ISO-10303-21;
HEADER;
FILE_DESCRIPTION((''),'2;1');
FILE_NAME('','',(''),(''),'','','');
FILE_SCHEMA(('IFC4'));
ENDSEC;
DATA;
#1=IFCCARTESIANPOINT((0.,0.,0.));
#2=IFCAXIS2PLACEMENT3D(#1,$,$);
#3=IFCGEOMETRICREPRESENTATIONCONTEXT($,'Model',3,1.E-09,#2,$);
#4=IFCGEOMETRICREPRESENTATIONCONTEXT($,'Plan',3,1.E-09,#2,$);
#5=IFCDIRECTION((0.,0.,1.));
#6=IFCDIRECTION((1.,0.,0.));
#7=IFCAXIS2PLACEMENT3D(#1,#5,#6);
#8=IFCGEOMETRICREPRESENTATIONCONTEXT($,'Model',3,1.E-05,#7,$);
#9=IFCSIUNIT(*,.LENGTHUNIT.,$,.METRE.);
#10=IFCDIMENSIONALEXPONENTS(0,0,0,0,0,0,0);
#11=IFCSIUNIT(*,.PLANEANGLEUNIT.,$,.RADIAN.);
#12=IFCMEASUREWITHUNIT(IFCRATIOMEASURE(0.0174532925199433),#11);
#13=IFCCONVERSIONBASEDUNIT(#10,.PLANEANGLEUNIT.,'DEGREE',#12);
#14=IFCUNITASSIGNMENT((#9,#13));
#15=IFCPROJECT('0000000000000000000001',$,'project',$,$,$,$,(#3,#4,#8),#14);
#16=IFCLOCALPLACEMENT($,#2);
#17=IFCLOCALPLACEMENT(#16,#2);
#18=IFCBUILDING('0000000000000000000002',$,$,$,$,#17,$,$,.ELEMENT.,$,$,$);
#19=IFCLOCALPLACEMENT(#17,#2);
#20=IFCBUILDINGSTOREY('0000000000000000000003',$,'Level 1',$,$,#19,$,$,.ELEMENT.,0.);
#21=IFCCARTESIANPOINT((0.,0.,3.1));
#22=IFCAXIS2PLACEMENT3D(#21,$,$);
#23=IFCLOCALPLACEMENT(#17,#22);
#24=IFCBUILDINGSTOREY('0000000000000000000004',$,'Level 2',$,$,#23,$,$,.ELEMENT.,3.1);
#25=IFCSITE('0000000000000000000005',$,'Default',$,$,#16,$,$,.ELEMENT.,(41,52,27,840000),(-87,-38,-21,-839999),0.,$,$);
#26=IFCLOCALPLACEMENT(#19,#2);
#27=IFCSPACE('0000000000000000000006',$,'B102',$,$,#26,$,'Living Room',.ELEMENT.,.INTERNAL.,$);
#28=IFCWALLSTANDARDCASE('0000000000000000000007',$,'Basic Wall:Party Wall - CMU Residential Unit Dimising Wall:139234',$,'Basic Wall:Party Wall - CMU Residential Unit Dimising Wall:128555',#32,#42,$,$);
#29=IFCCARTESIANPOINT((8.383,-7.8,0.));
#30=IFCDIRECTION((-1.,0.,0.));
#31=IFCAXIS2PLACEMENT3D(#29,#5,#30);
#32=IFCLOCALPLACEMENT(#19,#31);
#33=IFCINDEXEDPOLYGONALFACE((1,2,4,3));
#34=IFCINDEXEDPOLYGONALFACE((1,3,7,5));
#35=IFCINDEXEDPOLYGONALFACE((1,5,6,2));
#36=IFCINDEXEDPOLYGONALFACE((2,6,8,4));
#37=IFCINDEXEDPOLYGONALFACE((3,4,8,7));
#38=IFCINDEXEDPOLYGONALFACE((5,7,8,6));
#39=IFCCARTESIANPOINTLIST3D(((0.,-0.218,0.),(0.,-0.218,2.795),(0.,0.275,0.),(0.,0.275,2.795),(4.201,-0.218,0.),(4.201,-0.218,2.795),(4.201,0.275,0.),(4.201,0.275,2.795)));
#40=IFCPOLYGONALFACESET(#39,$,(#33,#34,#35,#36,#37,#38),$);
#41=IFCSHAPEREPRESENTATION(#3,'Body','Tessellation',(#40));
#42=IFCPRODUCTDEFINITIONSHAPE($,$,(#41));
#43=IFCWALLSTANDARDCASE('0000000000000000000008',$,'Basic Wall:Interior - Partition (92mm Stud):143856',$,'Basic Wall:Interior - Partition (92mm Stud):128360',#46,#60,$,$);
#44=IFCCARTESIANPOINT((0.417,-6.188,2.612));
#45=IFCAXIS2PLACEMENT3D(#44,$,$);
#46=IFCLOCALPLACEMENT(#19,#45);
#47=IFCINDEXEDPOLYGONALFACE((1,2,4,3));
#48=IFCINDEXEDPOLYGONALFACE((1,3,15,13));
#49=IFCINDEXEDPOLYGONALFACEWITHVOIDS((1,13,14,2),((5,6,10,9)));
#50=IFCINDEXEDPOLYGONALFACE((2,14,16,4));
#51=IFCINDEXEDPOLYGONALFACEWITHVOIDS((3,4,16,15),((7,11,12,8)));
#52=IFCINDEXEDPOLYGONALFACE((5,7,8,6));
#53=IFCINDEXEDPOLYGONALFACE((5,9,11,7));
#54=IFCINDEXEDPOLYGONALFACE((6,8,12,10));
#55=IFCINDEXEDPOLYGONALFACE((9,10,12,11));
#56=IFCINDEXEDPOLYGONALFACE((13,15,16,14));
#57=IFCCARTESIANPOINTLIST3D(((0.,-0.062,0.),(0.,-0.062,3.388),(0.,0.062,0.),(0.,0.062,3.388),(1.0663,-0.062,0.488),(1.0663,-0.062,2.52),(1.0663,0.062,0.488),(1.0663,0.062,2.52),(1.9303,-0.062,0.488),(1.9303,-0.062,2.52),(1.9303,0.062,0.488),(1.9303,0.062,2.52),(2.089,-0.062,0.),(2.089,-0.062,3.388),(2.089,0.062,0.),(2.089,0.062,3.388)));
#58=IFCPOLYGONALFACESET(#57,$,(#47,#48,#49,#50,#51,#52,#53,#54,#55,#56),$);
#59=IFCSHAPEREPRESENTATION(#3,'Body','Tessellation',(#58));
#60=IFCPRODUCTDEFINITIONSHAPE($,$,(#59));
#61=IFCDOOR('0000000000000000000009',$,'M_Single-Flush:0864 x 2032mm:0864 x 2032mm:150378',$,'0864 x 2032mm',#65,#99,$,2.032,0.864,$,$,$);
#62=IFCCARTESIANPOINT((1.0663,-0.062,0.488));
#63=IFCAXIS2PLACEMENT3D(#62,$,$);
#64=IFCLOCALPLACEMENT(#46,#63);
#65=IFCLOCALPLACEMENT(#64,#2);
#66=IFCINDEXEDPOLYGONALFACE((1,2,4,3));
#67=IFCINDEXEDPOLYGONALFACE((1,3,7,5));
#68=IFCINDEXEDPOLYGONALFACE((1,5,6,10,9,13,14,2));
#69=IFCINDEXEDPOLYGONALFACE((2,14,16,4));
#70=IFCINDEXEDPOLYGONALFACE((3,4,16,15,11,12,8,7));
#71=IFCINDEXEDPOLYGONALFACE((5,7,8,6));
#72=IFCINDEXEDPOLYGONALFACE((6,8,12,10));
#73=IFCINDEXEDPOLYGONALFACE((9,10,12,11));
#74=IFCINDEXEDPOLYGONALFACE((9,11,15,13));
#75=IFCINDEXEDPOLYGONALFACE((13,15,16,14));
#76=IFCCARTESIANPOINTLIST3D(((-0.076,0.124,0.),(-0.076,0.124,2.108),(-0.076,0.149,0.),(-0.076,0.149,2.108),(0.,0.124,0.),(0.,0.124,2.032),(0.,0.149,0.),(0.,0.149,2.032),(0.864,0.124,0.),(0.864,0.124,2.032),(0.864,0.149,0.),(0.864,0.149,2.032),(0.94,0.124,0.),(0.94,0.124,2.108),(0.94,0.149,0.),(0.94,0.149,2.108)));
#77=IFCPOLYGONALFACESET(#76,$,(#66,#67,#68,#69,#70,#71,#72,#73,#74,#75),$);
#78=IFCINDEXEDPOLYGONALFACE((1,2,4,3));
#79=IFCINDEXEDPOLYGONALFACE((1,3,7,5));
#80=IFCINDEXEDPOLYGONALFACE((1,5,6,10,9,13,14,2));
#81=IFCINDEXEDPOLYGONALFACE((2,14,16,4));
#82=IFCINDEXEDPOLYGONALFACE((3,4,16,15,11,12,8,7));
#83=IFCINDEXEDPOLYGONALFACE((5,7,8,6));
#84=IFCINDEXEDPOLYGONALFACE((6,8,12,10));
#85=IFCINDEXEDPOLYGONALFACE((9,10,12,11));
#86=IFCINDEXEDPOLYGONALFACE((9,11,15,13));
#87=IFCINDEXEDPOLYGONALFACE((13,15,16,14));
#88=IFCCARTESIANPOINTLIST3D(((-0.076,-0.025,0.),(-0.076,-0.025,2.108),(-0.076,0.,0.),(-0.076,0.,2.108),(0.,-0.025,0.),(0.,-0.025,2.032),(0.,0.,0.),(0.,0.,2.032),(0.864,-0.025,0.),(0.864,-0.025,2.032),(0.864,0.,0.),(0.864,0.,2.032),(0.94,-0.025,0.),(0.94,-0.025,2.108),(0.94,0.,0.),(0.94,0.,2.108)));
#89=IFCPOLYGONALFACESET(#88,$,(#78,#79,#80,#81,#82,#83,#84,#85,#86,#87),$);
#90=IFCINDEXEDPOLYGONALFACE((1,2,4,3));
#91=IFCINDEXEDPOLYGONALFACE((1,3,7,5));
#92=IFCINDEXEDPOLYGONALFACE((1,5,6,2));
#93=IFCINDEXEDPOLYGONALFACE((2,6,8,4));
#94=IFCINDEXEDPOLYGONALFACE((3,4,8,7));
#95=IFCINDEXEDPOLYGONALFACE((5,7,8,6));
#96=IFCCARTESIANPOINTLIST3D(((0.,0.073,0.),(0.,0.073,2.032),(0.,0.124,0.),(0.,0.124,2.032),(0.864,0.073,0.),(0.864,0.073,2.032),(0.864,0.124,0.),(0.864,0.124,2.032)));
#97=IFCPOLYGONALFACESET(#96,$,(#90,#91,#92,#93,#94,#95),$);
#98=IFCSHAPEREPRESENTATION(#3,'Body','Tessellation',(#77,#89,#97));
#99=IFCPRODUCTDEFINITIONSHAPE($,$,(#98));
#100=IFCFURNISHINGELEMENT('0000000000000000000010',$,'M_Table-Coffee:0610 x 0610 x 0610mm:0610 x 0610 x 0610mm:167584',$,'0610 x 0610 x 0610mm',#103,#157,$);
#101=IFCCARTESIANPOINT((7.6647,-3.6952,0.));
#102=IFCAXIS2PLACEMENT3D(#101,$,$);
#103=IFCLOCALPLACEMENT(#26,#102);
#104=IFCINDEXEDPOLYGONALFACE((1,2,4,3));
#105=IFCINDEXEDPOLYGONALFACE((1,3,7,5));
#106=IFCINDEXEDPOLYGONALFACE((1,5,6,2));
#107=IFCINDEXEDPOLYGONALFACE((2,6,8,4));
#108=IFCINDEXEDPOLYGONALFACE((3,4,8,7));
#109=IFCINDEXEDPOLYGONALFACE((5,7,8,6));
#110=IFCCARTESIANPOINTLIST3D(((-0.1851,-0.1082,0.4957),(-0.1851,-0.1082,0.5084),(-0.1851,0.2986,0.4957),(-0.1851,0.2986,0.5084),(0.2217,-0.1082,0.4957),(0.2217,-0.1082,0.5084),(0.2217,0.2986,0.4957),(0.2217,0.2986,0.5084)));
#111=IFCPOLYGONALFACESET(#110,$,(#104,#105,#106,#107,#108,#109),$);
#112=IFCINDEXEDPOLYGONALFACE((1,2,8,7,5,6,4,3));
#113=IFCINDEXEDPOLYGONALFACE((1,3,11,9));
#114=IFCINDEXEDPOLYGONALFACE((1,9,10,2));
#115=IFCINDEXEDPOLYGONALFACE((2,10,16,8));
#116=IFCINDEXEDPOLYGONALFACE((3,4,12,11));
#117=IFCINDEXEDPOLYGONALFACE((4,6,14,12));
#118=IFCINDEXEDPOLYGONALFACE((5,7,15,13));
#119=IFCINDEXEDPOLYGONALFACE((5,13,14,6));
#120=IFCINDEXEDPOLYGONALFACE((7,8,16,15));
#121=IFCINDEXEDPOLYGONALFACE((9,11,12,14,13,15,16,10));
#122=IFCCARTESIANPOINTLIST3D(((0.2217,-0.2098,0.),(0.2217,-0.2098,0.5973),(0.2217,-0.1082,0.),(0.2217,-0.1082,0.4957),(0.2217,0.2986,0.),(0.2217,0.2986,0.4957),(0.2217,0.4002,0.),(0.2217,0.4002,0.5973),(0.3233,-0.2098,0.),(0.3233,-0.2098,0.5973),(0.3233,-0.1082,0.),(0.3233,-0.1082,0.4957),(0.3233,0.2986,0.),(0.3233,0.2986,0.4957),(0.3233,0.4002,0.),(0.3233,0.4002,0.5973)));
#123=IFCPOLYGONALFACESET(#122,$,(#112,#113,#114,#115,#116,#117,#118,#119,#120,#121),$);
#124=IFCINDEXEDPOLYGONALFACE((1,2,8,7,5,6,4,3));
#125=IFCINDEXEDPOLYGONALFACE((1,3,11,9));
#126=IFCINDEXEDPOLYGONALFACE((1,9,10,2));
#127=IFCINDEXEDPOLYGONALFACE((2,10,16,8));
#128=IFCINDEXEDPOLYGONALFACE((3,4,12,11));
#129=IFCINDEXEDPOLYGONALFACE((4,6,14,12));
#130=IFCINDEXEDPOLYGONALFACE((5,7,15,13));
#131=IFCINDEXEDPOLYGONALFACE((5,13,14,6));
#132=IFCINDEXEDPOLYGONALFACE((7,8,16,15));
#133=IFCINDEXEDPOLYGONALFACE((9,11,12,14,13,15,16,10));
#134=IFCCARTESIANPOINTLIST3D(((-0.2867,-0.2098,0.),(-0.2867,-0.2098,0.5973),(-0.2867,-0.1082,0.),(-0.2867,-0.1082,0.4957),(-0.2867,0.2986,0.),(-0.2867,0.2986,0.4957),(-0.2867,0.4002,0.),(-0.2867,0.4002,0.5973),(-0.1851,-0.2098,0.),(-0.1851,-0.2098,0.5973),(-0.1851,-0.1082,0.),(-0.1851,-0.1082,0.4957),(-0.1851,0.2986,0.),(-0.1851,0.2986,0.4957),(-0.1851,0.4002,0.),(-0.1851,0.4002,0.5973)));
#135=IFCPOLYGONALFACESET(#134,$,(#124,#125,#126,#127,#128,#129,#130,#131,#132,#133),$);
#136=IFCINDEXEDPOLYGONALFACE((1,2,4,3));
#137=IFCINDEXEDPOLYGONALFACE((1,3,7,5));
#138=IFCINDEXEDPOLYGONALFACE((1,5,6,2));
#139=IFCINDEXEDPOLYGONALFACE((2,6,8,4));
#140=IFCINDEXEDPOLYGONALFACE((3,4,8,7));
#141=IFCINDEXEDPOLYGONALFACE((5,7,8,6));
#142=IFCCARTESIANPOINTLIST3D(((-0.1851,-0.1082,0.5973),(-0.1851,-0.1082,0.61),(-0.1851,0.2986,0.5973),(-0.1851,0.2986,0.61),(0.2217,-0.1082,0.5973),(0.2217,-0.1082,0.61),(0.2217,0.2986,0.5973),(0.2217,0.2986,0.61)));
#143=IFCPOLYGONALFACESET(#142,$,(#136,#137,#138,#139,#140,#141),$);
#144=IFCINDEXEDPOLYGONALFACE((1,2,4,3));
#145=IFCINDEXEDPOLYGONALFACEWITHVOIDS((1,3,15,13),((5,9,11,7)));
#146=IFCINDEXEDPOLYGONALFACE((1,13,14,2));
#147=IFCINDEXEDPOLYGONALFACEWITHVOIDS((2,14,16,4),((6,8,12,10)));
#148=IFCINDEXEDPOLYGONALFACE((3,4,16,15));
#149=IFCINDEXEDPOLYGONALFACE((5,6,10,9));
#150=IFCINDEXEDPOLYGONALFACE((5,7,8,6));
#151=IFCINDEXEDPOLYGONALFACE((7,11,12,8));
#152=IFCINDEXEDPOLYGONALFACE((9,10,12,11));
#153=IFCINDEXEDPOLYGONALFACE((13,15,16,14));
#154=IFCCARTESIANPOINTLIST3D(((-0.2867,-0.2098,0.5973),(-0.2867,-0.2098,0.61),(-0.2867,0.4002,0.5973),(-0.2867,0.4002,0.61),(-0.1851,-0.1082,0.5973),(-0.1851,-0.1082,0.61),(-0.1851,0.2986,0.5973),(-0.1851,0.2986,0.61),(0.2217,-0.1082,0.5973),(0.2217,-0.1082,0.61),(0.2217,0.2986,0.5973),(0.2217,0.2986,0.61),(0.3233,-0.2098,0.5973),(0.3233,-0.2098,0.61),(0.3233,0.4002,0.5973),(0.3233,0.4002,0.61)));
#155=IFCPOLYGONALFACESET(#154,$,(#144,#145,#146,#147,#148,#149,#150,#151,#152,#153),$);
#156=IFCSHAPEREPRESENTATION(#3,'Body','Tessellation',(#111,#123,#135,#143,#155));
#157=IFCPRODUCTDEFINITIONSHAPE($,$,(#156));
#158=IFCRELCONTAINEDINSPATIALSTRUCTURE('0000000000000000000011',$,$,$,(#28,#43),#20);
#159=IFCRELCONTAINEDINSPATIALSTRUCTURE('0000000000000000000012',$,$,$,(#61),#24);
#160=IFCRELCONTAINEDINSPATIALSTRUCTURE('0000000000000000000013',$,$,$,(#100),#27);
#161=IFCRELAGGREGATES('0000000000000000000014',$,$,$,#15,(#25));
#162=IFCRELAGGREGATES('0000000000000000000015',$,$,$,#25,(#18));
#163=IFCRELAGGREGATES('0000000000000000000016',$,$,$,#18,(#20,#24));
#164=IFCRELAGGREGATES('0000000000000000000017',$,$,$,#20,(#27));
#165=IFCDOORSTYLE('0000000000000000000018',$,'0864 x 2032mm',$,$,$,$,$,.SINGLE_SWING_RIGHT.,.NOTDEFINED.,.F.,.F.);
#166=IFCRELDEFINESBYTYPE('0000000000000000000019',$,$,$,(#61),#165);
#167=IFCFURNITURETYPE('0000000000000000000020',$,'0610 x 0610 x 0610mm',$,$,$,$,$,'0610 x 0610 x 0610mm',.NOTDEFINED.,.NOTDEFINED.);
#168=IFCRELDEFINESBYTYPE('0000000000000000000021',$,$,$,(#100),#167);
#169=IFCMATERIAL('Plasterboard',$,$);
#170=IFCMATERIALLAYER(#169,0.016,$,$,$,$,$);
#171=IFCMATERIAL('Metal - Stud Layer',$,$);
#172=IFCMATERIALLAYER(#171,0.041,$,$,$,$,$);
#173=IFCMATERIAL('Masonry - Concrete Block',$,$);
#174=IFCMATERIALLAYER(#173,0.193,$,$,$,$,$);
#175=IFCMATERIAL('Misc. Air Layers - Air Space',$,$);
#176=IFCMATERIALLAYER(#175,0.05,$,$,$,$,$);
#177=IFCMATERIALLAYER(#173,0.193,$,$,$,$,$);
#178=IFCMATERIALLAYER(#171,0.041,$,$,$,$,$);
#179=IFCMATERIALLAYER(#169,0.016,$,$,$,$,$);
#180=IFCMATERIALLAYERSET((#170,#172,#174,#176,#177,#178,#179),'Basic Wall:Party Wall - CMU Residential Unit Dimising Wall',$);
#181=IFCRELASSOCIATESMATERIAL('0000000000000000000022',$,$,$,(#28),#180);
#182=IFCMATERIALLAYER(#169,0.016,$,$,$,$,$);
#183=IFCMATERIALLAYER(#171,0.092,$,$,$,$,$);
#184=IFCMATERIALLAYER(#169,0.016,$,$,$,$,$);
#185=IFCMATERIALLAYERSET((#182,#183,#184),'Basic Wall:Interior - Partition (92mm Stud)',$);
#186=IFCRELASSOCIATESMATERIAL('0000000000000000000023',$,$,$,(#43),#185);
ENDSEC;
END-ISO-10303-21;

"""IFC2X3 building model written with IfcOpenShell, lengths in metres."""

from ifc_helpers import new_model, entity, si_unit, converted_unit, frame, frame_2d, origin, origin_with_axes, origin_2d_with_axis, place, context, project, spatial, polyline, rectangle, outline, extrude, clip, bounded_halfspace, source, transform, mapped, material, layer, layer_set, layer_usage, type_object, type_shapes, element, fill, save


model = new_model("IFC2X3")

# Units and contexts
model_context_1 = context("Model", 3, precision=1e-09, world=origin())
plan_context = context("Plan", 3, precision=1e-09, world=origin())
model_context_2 = context("Model", 3, precision=1e-05, world=origin_with_axes())
ifc_project = project(units=[si_unit("LENGTHUNIT", "METRE"), converted_unit("PLANEANGLEUNIT", "DEGREE", entity("IfcRatioMeasure", 0.0174532925199433), si_unit("PLANEANGLEUNIT", "RADIAN"), dimensions=[0, 0, 0, 0, 0, 0, 0])], contexts=[model_context_1, plan_context, model_context_2])

# Site, building, storey
site_placement = place(None, origin())
site = spatial("IfcSite", under=ifc_project, at=site_placement, Name="Default", CompositionType="ELEMENT", RefLatitude=(41, 52, 27, 840000), RefLongitude=(-87, -38, -21, -839999), RefElevation=0.0)
building_placement = place(site_placement, origin())
building = spatial("IfcBuilding", under=site, at=building_placement, CompositionType="ELEMENT")
storey_1_placement = place(building_placement, origin())
storey_1 = spatial("IfcBuildingStorey", under=building, at=storey_1_placement, Name="Level 1", CompositionType="ELEMENT", Elevation=0.0)

# Shared definitions
ifc_material_1 = material(Name="Misc. Air Layers - Air Space")
ifc_material_2 = material(Name="Masonry - Concrete Block")
ifc_material_3 = material(Name="Metal - Stud Layer")
ifc_material_4 = material(Name="Plasterboard")

# Shared definitions
ifc_layer_1 = layer(ifc_material_4, 0.016)
ifc_layer_2 = layer(ifc_material_3, 0.092)
ifc_layer_3 = layer(ifc_material_4, 0.016)
ifc_layer_set_1 = layer_set([ifc_layer_1, ifc_layer_2, ifc_layer_3], Name="Basic Wall:Interior - Partition (92mm Stud)")

# Wall
ifc_layer_4 = layer(ifc_material_4, 0.016)
ifc_layer_5 = layer(ifc_material_3, 0.041)
ifc_layer_6 = layer(ifc_material_2, 0.193)
ifc_layer_7 = layer(ifc_material_1, 0.05)
ifc_layer_8 = layer(ifc_material_2, 0.193)
ifc_layer_9 = layer(ifc_material_3, 0.041)
ifc_layer_10 = layer(ifc_material_4, 0.016)
ifc_layer_set_2 = layer_set([ifc_layer_4, ifc_layer_5, ifc_layer_6, ifc_layer_7, ifc_layer_8, ifc_layer_9, ifc_layer_10], Name="Basic Wall:Party Wall - CMU Residential Unit Dimising Wall")
ifc_layer_usage_1 = layer_usage(ifc_layer_set_2, "AXIS2", "NEGATIVE", 0.275)
wall_1_placement = place(storey_1_placement, frame((8.383, -7.8, 0.0), z_axis=(0.0, 0.0, 1.0), x_axis=(-1.0, 0.0, 0.0)))
element("IfcWallStandardCase", 1, at=wall_1_placement, inside=storey_1, material=ifc_layer_usage_1, Name="Basic Wall:Party Wall - CMU Residential Unit Dimising Wall:139234", ObjectType="Basic Wall:Party Wall - CMU Residential Unit Dimising Wall:128555", context=model_context_1, shape_type="Clipping", body=[
    clip(clip(extrude(rectangle(XDim=4.201, YDim=0.55, at=frame_2d((2.1005, 0.0), x_axis=(-1.0, 0.0))), origin(), (0.0, 0.0, 1.0), 2.795), bounded_halfspace(frame((0.0, -0.218, 2.795), z_axis=(0.0, 1.0, 0.0), x_axis=(-1.0, 0.0, 0.0)), True, frame((0.0, -0.218, 2.795), z_axis=(0.0, 1.0, 0.0), x_axis=(-1.0, 0.0, 0.0)), polyline([(0.0, 0.0), (-3.708, 0.0), (-4.201, 0.0), (-4.201, -2.795), (0.0, -2.795), (0.0, 0.0)]))), bounded_halfspace(frame((4.201, 0.275, 0.0), z_axis=(-1.0, 0.0, 0.0), x_axis=(0.0, -1.0, 0.0)), True, frame((4.201, 0.275, 0.0), z_axis=(-1.0, 0.0, 0.0), x_axis=(0.0, -1.0, 0.0)), polyline([(0.0, 0.0), (0.493, 0.0), (0.493, 2.795), (0.0, 2.795), (0.0, 0.0)]))),
])

# Wall, opening
ifc_layer_usage_2 = layer_usage(ifc_layer_set_1, "AXIS2", "NEGATIVE", 0.062)
wall_2_placement = place(storey_1_placement, frame((0.417, -6.188, 2.612)))
wall_2 = element("IfcWallStandardCase", 2, at=wall_2_placement, inside=storey_1, material=ifc_layer_usage_2, Name="Basic Wall:Interior - Partition (92mm Stud):143856", ObjectType="Basic Wall:Interior - Partition (92mm Stud):128360", context=model_context_1, shape_type="SweptSolid", body=[
    extrude(rectangle(XDim=2.089, YDim=0.124, at=frame_2d((1.0445, 0.0), x_axis=(-1.0, 0.0))), origin(), (0.0, 0.0, 1.0), 3.388),
])
opening_1_placement = place(wall_2_placement, frame((1.0663, -0.062, 0.488)))
opening_1 = element("IfcOpeningElement", 3, at=opening_1_placement, cuts=wall_2, ObjectType="Opening", context=model_context_1, shape_type="SweptSolid", body=[
    extrude(rectangle(XDim=0.864, YDim=2.032, at=frame_2d((1.016, 0.432), x_axis=(0.0, 1.0))), frame((0.0, 0.0, 0.0), z_axis=(0.0, 1.0, 0.0), x_axis=(0.0, 0.0, 1.0)), (0.0, 0.0, 1.0), 0.124),
])

# Shared definitions
storey_2_placement = place(building_placement, frame((0.0, 0.0, 3.1)))
storey_2 = spatial("IfcBuildingStorey", under=building, at=storey_2_placement, Name="Level 2", CompositionType="ELEMENT", Elevation=3.1)

# Door
door_style_1 = type_object("IfcDoorStyle", Name="0864 x 2032mm", ConstructionType="NOTDEFINED", OperationType="SINGLE_SWING_RIGHT", ParameterTakesPrecedence=False, Sizeable=False)
shared_shape_1 = source(origin(), model_context_1, "Body", "SweptSolid", [
    extrude(outline(polyline([(-0.508, -1.073), (0.508, -1.073), (0.508, 1.035), (0.432, 1.035), (0.432, -0.997), (-0.432, -0.997), (-0.432, 1.035), (-0.508, 1.035), (-0.508, -1.073)])), frame((0.432, 0.124, 1.035), z_axis=(0.0, 1.0, 0.0), x_axis=(1.0, 0.0, 0.0)), (0.0, 0.0, 1.0), 0.025),
    extrude(outline(polyline([(-1.073, -0.508), (1.035, -0.508), (1.035, -0.432), (-0.997, -0.432), (-0.997, 0.432), (1.035, 0.432), (1.035, 0.508), (-1.073, 0.508), (-1.073, -0.508)])), frame((0.432, -0.025, 1.035), z_axis=(0.0, 1.0, 0.0), x_axis=(0.0, 0.0, -1.0)), (0.0, 0.0, 1.0), 0.025),
    extrude(rectangle(XDim=0.051, YDim=0.864, at=origin_2d_with_axis()), frame((0.432, 0.0985, 0.0), z_axis=(0.0, 0.0, 1.0), x_axis=(0.0, 1.0, 0.0)), (0.0, 0.0, 1.0), 2.032),
])
type_shapes(door_style_1, [shared_shape_1])
door_1_placement = place(opening_1_placement, origin())
door_1 = element("IfcDoor", 4, at=door_1_placement, inside=storey_2, type_object=door_style_1, Name="M_Single-Flush:0864 x 2032mm:0864 x 2032mm:150378", ObjectType="0864 x 2032mm", OverallHeight=2.032, OverallWidth=0.864, context=model_context_1, shape_type="MappedRepresentation", body=[
    mapped(shared_shape_1, transform((0.0, 0.0, 0.0), scale=1.0)),
])
fill(opening_1, door_1)

# Shared definitions
space_1_placement = place(storey_1_placement, origin())
space_1 = spatial("IfcSpace", under=storey_1, at=space_1_placement, Name="B102", LongName="Living Room", CompositionType="ELEMENT", InteriorOrExteriorSpace="INTERNAL")

# Furnishing element
furniture_type_1 = type_object("IfcFurnitureType", Name="0610 x 0610 x 0610mm", ElementType="0610 x 0610 x 0610mm", AssemblyPlace="NOTDEFINED")
shared_shape_2 = source(origin(), model_context_1, "Body", "SweptSolid", [
    extrude(rectangle(XDim=0.4068, YDim=0.4068, at=origin_2d_with_axis()), frame((0.0183, 0.0952, 0.4957), z_axis=(0.0, 0.0, 1.0), x_axis=(-1.0, 0.0, 0.0)), (0.0, 0.0, 1.0), 0.0127),
    extrude(outline(polyline([(-0.2732, -0.305), (0.324, -0.305), (0.324, 0.305), (-0.2732, 0.305), (-0.2732, 0.2034), (0.2225, 0.2034), (0.2225, -0.2034), (-0.2732, -0.2034), (-0.2732, -0.305)])), frame((0.2217, 0.0952, 0.2732), z_axis=(1.0, 0.0, 0.0), x_axis=(0.0, 0.0, 1.0)), (0.0, 0.0, 1.0), 0.1016),
    extrude(outline(polyline([(-0.305, -0.3241), (0.305, -0.3241), (0.305, 0.2733), (0.2034, 0.2733), (0.2034, -0.2224), (-0.2034, -0.2224), (-0.2034, 0.2733), (-0.305, 0.2733), (-0.305, -0.3241)])), frame((-0.2867, 0.0952, 0.2733), z_axis=(1.0, 0.0, 0.0), x_axis=(0.0, -1.0, 0.0)), (0.0, 0.0, 1.0), 0.1016),
    extrude(rectangle(XDim=0.4068, YDim=0.4068, at=origin_2d_with_axis()), frame((0.0183, 0.0952, 0.5973), z_axis=(0.0, 0.0, 1.0), x_axis=(-1.0, 0.0, 0.0)), (0.0, 0.0, 1.0), 0.0127),
    extrude(outline(polyline([(-0.305, -0.305), (0.305, -0.305), (0.305, 0.305), (-0.305, 0.305), (-0.305, -0.305)]), holes=[polyline([(-0.2034, -0.2034), (-0.2034, 0.2034), (0.2034, 0.2034), (0.2034, -0.2034), (-0.2034, -0.2034)])]), frame((0.0183, 0.0952, 0.5973), z_axis=(0.0, 0.0, 1.0), x_axis=(-1.0, 0.0, 0.0)), (0.0, 0.0, 1.0), 0.0127),
])
type_shapes(furniture_type_1, [shared_shape_2])
for number, where, name in (
    (5, (7.6647, -3.6952, 0.0), "M_Table-Coffee:0610 x 0610 x 0610mm:0610 x 0610 x 0610mm:167584"),
):
    element("IfcFurnishingElement", number, at=place(space_1_placement, frame(where)), inside=space_1, type_object=furniture_type_1, Name=name, ObjectType="0610 x 0610 x 0610mm", context=model_context_1, shape_type="MappedRepresentation", body=[
        mapped(shared_shape_2, transform((0.0, 0.0, 0.0), scale=1.0)),
    ])

save(model, "model.ifc")
